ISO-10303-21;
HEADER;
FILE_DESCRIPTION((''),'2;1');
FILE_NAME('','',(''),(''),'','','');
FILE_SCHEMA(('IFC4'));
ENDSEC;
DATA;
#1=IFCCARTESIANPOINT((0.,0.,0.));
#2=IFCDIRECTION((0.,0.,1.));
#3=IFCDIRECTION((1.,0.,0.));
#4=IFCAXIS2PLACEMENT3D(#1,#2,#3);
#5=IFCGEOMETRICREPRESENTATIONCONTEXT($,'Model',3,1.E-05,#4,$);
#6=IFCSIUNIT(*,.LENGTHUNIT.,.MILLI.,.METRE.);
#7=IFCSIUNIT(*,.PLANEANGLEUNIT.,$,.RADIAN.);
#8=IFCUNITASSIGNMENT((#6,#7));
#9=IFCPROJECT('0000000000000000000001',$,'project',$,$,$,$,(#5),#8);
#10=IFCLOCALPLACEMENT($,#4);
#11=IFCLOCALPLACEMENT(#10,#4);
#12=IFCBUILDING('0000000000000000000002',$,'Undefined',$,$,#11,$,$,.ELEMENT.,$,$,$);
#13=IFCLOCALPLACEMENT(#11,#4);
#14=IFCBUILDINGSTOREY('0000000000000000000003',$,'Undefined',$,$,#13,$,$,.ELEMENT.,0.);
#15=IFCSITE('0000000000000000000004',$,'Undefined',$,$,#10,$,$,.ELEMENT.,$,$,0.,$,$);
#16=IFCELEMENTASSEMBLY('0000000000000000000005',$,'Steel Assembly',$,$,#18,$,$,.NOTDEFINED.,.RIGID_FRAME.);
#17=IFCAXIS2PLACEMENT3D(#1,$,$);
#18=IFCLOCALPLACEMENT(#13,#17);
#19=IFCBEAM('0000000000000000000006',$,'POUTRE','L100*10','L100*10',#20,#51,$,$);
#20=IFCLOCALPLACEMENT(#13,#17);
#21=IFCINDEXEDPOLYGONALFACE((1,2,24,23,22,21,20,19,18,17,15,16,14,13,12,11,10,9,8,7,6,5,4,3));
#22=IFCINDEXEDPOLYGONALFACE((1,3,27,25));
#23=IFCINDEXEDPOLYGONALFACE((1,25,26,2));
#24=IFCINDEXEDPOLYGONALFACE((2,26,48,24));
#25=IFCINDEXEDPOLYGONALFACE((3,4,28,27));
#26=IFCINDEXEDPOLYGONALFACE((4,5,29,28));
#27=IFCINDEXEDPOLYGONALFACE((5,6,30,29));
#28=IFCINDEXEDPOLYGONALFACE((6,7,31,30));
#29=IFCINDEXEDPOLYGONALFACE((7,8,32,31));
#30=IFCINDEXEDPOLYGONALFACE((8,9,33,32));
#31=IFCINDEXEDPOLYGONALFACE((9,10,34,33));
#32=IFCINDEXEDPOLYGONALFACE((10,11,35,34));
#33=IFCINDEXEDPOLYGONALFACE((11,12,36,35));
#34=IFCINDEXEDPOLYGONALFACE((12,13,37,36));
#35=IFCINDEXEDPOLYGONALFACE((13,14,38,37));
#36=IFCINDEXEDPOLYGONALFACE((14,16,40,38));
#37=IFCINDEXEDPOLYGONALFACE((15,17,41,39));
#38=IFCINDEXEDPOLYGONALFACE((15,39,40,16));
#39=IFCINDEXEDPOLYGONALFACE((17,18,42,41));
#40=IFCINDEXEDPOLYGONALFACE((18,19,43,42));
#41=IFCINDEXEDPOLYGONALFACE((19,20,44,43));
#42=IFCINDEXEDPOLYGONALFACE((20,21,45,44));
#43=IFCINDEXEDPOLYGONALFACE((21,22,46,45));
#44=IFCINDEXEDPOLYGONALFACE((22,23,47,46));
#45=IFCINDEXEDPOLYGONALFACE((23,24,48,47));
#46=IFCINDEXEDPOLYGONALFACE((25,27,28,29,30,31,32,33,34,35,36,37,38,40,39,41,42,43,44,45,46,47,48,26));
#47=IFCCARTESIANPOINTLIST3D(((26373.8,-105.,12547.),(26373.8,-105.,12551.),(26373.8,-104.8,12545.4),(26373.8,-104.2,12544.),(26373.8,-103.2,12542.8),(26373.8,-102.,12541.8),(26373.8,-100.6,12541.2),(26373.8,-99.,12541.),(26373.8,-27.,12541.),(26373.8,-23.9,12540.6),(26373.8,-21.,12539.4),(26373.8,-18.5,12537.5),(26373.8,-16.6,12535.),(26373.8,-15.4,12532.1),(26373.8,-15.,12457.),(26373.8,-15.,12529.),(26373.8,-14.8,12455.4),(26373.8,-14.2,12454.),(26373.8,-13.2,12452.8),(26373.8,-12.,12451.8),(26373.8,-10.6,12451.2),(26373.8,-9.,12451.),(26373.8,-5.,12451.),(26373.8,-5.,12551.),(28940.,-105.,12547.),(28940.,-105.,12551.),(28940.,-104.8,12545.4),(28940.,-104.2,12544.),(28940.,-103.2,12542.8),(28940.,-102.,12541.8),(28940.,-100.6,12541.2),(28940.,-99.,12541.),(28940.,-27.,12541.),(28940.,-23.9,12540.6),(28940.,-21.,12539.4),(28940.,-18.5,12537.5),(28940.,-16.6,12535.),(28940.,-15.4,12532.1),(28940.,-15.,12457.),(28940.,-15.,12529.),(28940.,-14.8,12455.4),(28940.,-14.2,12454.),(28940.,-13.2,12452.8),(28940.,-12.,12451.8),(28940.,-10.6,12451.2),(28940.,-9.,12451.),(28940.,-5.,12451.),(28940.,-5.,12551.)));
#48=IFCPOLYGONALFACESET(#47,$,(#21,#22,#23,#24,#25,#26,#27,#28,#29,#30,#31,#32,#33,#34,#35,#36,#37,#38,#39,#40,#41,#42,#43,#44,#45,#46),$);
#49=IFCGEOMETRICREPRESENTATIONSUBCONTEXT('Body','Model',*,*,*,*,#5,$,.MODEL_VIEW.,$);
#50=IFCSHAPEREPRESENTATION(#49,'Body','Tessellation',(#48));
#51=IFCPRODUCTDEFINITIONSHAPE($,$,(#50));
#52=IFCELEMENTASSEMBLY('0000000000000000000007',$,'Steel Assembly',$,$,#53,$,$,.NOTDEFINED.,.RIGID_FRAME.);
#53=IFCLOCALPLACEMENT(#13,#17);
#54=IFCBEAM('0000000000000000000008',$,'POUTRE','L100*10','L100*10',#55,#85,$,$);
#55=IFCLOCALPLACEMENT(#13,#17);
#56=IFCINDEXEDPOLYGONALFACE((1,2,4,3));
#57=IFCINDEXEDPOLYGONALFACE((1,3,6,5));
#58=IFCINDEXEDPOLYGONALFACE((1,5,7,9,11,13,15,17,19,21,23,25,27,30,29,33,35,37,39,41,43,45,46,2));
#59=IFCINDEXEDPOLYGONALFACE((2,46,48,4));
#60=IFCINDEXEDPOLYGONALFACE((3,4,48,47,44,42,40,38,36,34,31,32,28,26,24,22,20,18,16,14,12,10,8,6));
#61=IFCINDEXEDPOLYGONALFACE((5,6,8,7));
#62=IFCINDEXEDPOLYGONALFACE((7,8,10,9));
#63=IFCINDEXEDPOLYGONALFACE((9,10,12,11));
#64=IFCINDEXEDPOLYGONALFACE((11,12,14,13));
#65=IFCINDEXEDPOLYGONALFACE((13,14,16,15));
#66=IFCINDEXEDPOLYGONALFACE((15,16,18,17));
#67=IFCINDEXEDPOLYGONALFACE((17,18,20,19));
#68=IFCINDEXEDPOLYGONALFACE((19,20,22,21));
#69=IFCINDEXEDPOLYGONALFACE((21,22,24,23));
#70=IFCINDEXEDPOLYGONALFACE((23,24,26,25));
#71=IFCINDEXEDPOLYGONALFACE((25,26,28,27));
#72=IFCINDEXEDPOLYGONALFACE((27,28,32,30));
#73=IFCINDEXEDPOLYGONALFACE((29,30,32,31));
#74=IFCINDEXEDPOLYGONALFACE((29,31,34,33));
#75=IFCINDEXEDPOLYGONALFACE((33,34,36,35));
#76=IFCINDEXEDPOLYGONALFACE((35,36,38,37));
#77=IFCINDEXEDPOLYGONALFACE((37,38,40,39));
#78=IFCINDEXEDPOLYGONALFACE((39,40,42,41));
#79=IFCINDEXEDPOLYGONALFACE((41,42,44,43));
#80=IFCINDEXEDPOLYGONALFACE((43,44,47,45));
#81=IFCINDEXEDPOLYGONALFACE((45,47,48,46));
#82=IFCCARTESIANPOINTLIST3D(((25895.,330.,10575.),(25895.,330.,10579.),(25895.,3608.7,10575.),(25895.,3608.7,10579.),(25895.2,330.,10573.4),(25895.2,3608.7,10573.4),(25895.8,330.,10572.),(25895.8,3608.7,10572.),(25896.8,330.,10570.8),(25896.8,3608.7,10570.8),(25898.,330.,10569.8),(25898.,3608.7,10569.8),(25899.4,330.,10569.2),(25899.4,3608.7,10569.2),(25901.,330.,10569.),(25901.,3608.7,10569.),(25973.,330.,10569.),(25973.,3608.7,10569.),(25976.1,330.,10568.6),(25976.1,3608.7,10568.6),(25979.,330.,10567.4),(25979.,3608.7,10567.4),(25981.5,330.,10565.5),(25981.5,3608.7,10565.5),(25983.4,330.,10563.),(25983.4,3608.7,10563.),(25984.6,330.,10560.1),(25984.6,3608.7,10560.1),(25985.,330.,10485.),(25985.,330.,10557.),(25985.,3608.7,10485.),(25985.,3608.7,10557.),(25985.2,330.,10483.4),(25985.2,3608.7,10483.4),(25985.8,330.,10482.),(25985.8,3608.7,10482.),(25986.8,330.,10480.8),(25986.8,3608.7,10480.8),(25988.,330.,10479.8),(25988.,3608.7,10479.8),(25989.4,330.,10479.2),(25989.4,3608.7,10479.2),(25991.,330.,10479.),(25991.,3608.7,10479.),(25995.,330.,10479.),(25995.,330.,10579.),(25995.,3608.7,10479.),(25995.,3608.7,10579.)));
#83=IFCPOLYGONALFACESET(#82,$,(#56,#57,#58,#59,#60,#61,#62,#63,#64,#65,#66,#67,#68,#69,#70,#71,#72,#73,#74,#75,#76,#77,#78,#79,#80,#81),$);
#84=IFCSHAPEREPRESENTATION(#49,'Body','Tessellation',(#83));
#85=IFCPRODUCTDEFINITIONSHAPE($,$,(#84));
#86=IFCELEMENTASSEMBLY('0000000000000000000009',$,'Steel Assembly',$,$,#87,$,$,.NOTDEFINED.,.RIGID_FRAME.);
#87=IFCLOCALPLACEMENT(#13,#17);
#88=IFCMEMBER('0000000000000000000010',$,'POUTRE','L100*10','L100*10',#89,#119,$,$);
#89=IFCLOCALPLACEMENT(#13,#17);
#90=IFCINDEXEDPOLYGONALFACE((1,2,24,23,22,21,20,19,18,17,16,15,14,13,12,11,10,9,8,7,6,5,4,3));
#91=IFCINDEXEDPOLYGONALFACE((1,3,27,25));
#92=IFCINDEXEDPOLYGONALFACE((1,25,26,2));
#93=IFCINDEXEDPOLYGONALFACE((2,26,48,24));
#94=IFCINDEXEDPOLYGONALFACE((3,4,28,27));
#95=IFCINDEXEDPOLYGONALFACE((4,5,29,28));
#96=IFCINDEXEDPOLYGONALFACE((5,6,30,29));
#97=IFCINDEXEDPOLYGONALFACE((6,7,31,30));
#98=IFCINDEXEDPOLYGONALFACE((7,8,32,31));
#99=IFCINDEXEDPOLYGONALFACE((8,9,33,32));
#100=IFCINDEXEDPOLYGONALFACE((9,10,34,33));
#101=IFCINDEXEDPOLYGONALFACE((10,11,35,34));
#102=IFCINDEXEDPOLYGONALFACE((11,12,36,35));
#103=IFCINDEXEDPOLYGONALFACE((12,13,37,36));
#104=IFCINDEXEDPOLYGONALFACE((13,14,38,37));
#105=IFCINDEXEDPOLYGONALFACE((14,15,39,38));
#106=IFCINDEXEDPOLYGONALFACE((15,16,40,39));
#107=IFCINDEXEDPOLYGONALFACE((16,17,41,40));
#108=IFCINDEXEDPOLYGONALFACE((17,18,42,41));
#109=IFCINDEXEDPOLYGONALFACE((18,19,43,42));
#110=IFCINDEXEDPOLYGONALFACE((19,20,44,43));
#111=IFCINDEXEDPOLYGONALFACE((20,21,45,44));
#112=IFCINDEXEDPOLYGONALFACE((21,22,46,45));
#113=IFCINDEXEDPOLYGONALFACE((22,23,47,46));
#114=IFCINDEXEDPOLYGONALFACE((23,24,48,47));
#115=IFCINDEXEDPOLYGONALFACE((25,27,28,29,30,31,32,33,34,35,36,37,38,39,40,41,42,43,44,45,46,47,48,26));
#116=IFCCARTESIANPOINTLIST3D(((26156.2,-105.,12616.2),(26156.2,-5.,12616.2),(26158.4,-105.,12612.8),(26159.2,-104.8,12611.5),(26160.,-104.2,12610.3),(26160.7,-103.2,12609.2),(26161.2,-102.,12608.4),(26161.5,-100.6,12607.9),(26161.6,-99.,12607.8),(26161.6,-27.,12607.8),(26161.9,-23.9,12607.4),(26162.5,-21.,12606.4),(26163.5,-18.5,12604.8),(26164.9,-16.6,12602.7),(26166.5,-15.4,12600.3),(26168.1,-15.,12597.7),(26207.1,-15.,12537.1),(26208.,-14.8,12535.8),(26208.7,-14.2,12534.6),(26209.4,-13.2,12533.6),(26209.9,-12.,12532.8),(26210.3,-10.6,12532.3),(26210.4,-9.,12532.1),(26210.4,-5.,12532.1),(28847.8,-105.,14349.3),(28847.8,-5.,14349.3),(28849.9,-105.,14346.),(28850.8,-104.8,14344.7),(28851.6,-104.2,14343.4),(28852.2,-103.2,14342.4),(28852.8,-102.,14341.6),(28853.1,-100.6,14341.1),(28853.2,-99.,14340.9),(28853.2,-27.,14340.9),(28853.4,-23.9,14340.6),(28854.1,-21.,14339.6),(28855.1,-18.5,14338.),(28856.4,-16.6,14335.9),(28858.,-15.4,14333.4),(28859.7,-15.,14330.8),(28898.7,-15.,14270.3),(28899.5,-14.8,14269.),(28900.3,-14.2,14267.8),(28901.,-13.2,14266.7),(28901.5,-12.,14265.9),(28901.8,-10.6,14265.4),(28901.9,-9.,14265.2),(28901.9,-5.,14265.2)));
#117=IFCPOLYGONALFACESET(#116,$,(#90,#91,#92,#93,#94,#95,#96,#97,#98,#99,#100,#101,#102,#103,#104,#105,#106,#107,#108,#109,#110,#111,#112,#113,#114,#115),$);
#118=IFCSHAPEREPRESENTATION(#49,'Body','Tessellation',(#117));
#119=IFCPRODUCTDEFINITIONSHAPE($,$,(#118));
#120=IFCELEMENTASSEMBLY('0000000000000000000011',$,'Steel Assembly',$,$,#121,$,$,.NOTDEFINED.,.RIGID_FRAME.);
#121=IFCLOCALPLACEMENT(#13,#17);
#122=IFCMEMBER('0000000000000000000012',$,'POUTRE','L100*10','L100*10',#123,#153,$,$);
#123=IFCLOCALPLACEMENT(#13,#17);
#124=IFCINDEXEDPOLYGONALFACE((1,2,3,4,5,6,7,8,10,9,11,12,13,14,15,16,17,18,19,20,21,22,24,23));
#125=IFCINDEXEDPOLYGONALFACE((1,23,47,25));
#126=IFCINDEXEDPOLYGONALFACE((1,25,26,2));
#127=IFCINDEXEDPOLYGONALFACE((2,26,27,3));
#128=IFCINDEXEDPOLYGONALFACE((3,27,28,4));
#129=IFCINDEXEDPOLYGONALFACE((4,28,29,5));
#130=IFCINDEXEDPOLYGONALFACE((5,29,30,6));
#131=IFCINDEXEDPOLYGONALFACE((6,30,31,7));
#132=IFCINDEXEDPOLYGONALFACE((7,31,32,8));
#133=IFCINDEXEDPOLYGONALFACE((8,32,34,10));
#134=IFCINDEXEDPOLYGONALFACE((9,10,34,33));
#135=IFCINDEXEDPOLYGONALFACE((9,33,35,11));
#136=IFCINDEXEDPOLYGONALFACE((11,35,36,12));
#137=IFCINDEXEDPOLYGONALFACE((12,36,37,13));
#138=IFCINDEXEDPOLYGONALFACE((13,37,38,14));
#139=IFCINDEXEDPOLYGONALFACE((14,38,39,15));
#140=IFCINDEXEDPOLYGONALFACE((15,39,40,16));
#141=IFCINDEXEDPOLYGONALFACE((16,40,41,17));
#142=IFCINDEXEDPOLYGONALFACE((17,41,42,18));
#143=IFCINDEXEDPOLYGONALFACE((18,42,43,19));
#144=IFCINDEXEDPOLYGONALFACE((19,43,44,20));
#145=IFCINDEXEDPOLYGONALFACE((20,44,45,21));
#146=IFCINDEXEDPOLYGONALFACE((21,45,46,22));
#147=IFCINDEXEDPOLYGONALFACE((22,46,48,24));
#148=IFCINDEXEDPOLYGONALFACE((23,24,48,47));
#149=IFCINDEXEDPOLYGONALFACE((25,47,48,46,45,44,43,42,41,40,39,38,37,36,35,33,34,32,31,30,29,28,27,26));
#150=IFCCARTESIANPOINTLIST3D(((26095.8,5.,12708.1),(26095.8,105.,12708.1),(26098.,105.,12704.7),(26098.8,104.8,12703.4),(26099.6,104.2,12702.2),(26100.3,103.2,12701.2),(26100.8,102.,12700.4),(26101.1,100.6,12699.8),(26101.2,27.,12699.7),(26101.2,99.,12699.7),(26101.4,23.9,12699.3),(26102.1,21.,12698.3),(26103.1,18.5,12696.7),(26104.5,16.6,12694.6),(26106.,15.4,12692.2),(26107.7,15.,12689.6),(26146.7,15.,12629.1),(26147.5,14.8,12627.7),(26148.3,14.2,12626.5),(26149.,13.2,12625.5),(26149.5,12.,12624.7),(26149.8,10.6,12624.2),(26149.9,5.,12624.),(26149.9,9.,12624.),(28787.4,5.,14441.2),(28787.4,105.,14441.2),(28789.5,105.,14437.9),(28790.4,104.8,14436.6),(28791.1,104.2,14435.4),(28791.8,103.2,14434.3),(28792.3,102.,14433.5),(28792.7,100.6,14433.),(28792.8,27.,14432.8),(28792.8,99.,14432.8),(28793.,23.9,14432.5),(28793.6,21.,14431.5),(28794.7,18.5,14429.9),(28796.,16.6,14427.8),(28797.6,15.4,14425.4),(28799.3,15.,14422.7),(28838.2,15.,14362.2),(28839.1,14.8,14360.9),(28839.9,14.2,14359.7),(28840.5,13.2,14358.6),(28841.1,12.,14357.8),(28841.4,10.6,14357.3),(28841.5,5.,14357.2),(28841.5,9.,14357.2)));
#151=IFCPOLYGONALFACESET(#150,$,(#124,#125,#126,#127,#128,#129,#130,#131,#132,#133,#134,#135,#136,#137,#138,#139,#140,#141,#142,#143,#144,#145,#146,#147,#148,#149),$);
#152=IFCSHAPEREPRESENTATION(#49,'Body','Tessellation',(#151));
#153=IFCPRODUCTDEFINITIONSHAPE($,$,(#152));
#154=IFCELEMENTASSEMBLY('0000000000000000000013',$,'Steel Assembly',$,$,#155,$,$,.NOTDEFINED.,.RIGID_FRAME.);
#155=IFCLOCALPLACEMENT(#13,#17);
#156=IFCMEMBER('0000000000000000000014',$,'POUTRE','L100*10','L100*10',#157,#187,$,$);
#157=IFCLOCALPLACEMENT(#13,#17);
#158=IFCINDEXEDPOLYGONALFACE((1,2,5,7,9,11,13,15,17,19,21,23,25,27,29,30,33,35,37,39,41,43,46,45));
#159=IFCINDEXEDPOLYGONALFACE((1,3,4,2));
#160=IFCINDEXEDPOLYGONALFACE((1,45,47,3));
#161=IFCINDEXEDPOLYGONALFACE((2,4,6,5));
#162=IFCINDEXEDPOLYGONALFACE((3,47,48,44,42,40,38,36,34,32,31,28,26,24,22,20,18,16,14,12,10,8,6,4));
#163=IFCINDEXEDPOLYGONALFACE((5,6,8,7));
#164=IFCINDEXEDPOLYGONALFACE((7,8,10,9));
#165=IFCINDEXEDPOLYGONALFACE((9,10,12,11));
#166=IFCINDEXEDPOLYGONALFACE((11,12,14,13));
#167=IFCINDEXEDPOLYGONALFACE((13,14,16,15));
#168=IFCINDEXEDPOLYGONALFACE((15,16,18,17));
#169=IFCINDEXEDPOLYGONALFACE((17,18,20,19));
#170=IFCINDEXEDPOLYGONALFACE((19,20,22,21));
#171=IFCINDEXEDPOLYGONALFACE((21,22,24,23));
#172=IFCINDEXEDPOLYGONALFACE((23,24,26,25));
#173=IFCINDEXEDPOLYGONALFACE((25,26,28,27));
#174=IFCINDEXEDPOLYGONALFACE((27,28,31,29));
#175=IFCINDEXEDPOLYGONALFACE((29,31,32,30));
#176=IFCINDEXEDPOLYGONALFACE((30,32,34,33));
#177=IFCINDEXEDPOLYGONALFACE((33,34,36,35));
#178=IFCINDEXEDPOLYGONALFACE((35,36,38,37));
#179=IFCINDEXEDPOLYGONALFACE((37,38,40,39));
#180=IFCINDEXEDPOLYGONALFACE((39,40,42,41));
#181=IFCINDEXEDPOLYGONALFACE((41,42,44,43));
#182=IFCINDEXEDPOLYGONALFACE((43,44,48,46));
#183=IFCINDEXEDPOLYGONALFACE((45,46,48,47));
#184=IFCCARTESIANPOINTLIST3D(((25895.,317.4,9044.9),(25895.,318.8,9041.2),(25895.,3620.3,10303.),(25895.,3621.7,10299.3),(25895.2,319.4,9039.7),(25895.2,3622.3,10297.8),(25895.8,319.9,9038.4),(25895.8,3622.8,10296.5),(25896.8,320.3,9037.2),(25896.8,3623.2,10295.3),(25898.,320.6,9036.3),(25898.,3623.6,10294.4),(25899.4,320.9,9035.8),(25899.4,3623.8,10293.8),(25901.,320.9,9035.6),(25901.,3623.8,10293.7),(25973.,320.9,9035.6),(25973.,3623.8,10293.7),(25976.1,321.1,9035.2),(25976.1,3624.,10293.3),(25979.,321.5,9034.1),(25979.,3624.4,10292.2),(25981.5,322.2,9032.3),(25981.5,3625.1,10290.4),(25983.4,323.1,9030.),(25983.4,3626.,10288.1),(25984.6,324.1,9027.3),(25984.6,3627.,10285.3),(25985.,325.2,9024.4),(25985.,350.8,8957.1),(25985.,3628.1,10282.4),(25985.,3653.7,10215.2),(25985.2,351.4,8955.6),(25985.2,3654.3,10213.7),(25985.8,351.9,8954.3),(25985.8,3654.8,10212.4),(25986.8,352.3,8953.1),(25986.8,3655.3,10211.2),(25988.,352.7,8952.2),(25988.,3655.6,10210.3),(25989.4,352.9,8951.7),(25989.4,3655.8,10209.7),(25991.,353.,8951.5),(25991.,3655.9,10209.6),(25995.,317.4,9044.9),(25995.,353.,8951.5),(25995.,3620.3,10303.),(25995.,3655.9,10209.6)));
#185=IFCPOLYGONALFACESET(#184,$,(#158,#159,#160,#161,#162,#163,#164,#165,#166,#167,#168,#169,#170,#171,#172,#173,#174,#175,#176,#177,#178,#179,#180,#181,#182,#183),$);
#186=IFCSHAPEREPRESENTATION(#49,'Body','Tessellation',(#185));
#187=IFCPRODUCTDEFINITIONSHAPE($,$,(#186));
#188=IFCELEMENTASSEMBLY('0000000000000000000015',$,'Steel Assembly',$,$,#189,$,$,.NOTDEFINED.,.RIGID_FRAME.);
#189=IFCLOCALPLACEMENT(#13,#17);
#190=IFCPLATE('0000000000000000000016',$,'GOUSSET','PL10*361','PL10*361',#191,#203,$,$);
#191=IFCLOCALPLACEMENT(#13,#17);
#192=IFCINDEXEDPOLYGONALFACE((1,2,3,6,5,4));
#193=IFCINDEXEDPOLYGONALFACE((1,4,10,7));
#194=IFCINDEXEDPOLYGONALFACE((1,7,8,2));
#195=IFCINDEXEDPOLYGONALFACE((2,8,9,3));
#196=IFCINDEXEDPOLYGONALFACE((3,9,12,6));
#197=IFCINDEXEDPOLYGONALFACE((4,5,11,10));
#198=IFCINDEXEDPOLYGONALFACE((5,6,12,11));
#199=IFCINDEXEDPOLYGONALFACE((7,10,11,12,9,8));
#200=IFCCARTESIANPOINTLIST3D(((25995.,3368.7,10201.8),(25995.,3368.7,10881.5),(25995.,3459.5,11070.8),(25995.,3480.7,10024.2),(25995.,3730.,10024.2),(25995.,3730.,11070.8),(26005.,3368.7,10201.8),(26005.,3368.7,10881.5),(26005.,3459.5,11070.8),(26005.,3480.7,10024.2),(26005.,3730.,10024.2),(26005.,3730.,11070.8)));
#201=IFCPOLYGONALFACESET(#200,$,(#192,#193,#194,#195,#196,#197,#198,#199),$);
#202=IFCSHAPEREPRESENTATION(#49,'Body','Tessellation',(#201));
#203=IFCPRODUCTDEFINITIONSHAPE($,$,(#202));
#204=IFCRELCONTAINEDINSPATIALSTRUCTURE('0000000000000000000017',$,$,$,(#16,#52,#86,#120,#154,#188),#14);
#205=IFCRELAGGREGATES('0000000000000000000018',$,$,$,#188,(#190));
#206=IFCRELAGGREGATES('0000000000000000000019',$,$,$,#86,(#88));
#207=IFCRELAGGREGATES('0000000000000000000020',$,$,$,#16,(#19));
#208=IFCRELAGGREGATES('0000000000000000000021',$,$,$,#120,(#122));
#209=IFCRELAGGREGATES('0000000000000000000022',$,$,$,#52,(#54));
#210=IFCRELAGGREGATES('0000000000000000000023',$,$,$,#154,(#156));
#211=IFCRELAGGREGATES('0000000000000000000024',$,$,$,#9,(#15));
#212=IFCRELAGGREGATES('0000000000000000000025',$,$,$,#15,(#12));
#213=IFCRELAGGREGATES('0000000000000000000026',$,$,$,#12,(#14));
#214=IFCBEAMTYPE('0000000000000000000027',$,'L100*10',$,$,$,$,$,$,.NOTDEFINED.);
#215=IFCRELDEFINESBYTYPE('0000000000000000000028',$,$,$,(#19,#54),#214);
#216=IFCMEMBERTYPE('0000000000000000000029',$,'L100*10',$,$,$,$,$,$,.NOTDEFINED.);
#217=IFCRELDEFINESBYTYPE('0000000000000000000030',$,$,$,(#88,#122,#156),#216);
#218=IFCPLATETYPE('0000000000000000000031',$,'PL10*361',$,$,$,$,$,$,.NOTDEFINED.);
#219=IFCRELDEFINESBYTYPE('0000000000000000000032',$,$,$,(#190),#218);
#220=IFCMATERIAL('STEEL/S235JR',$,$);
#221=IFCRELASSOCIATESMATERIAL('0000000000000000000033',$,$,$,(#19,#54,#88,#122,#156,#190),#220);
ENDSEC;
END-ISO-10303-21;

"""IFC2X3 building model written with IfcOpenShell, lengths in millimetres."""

from ifc_helpers import new_model, si_unit, frame, origin_with_axes, origin_2d_with_axis, place, context, subcontext, project, spatial, polyline, l_section, outline, extrude, material, type_object, element, aggregate, save


model = new_model("IFC2X3")

# Units and contexts
model_context = context("Model", 3, precision=1e-05, world=origin_with_axes())
body_context = subcontext(model_context, "Body", "Model", "MODEL_VIEW")
ifc_project = project(units=[si_unit("LENGTHUNIT", "METRE", prefix="MILLI"), si_unit("PLANEANGLEUNIT", "RADIAN")], contexts=[model_context])

# Site, building, storey
site_placement = place(None, origin_with_axes())
site = spatial("IfcSite", under=ifc_project, at=site_placement, Name="Undefined", CompositionType="ELEMENT", RefElevation=0.0)
building_placement = place(site_placement, origin_with_axes())
building = spatial("IfcBuilding", under=site, at=building_placement, Name="Undefined", CompositionType="ELEMENT")
storey_placement = place(building_placement, origin_with_axes())
storey = spatial("IfcBuildingStorey", under=building, at=storey_placement, Name="Undefined", CompositionType="ELEMENT", Elevation=0.0)

# Element assemblies, beams
assembly_1_placement = place(storey_placement, origin_with_axes())
assembly_1 = element("IfcElementAssembly", 1, at=assembly_1_placement, inside=storey, Name="Steel Assembly", AssemblyPlace="NOTDEFINED", PredefinedType="RIGID_FRAME")
ifc_material_1 = material(Name="STEEL/S235JR")
beam_type = type_object("IfcBeamType", Name="L100*10", PredefinedType="NOTDEFINED")
beam_1_placement = place(assembly_1_placement, frame((26373.8, -55.0, 12501.0), z_axis=(0.0, -1.0, 0.0), x_axis=(1.0, 0.0, 0.0)))
beam_1 = element("IfcBeam", 2, at=beam_1_placement, type_object=beam_type, material=ifc_material_1, Name="POUTRE", Description="L100*10", ObjectType="L100*10", context=body_context, shape_type="SweptSolid", body=[
    extrude(l_section(Depth=100.0, Width=100.0, Thickness=10.0, FilletRadius=12.0, EdgeRadius=6.0, at=origin_2d_with_axis()), frame((2566.2, 0.0, 0.0), z_axis=(-1.0, 0.0, 0.0), x_axis=(0.0, -1.0, 0.0)), (0.0, 0.0, 1.0), 2566.2),
])
assembly_2_placement = place(storey_placement, origin_with_axes())
assembly_2 = element("IfcElementAssembly", 3, at=assembly_2_placement, inside=storey, Name="Steel Assembly", AssemblyPlace="NOTDEFINED", PredefinedType="RIGID_FRAME")
beam_2_placement = place(assembly_2_placement, frame((25945.0, 3608.7, 10529.0), z_axis=(-1.0, 0.0, 0.0), x_axis=(0.0, -1.0, 0.0)))
beam_2 = element("IfcBeam", 4, at=beam_2_placement, type_object=beam_type, material=ifc_material_1, Name="POUTRE", Description="L100*10", ObjectType="L100*10", context=body_context, shape_type="SweptSolid", body=[
    extrude(l_section(Depth=100.0, Width=100.0, Thickness=10.0, FilletRadius=12.0, EdgeRadius=6.0, at=origin_2d_with_axis()), frame((3278.7, 0.0, 0.0), z_axis=(-1.0, 0.0, 0.0), x_axis=(0.0, -1.0, 0.0)), (0.0, 0.0, 1.0), 3278.7),
])

# Element assemblies, members
assembly_3_placement = place(storey_placement, origin_with_axes())
assembly_3 = element("IfcElementAssembly", 5, at=assembly_3_placement, inside=storey, Name="Steel Assembly", AssemblyPlace="NOTDEFINED", PredefinedType="RIGID_FRAME")
member_type = type_object("IfcMemberType", Name="L100*10", PredefinedType="NOTDEFINED")
member_1_placement = place(assembly_3_placement, frame((26183.3, -55.0, 12574.1), z_axis=(0.0, -1.0, 0.0), x_axis=(0.84077, 0.0, 0.541392)))
member_1 = element("IfcMember", 6, at=member_1_placement, type_object=member_type, material=ifc_material_1, Name="POUTRE", Description="L100*10", ObjectType="L100*10", context=body_context, shape_type="SweptSolid", body=[
    extrude(l_section(Depth=100.0, Width=100.0, Thickness=10.0, FilletRadius=12.0, EdgeRadius=6.0, at=origin_2d_with_axis()), frame((3201.3, 0.0, 0.0), z_axis=(-1.0, 0.0, 0.0), x_axis=(0.0, -1.0, 0.0)), (0.0, 0.0, 1.0), 3201.3),
])
assembly_4_placement = place(storey_placement, origin_with_axes())
assembly_4 = element("IfcElementAssembly", 7, at=assembly_4_placement, inside=storey, Name="Steel Assembly", AssemblyPlace="NOTDEFINED", PredefinedType="RIGID_FRAME")
member_2_placement = place(assembly_4_placement, frame((26122.8, 55.0, 12666.0), z_axis=(0.541392, 0.0, -0.84077), x_axis=(0.84077, 0.0, 0.541392)))
member_2 = element("IfcMember", 8, at=member_2_placement, type_object=member_type, material=ifc_material_1, Name="POUTRE", Description="L100*10", ObjectType="L100*10", context=body_context, shape_type="SweptSolid", body=[
    extrude(l_section(Depth=100.0, Width=100.0, Thickness=10.0, FilletRadius=12.0, EdgeRadius=6.0, at=origin_2d_with_axis()), frame((3201.3, 0.0, 0.0), z_axis=(-1.0, 0.0, 0.0), x_axis=(0.0, -1.0, 0.0)), (0.0, 0.0, 1.0), 3201.3),
])
assembly_5_placement = place(storey_placement, origin_with_axes())
assembly_5 = element("IfcElementAssembly", 9, at=assembly_5_placement, inside=storey, Name="Steel Assembly", AssemblyPlace="NOTDEFINED", PredefinedType="RIGID_FRAME")
member_3_placement = place(assembly_5_placement, frame((25945.0, 335.2, 8998.2), z_axis=(0.0, 0.355951, -0.934505), x_axis=(0.0, 0.934505, 0.355951)))
member_3 = element("IfcMember", 10, at=member_3_placement, type_object=member_type, material=ifc_material_1, Name="POUTRE", Description="L100*10", ObjectType="L100*10", context=body_context, shape_type="SweptSolid", body=[
    extrude(l_section(Depth=100.0, Width=100.0, Thickness=10.0, FilletRadius=12.0, EdgeRadius=6.0, at=origin_2d_with_axis()), frame((3534.4, 0.0, 0.0), z_axis=(-1.0, 0.0, 0.0), x_axis=(0.0, -1.0, 0.0)), (0.0, 0.0, 1.0), 3534.4),
])

# Element assembly, plate
assembly_6_placement = place(storey_placement, origin_with_axes())
assembly_6 = element("IfcElementAssembly", 11, at=assembly_6_placement, inside=storey, Name="Steel Assembly", AssemblyPlace="NOTDEFINED", PredefinedType="RIGID_FRAME")
plate_type = type_object("IfcPlateType", Name="PL10*361", PredefinedType="NOTDEFINED")
plate_1_placement = place(assembly_6_placement, frame((26000.0, 3459.5, 11070.8), z_axis=(-1.0, 0.0, 0.0), x_axis=(0.0, 1.0, 0.0)))
plate_1 = element("IfcPlate", 12, at=plate_1_placement, type_object=plate_type, material=ifc_material_1, Name="GOUSSET", Description="PL10*361", ObjectType="PL10*361", context=body_context, shape_type="SweptSolid", body=[
    extrude(outline(polyline([(0.0, 0.0), (270.5, 0.0), (270.5, 1046.7), (21.3, 1046.7), (-90.7, 869.1), (-90.7, 189.4), (0.0, 0.0)])), frame((0.0, 0.0, -5.0), z_axis=(0.0, 0.0, 1.0), x_axis=(1.0, 0.0, 0.0)), (0.0, 0.0, 1.0), 10.0),
])
aggregate(assembly_6, [plate_1])

aggregate(assembly_3, [member_1])

aggregate(assembly_1, [beam_1])

aggregate(assembly_4, [member_2])

aggregate(assembly_2, [beam_2])
aggregate(assembly_5, [member_3])

save(model, "model.ifc")
